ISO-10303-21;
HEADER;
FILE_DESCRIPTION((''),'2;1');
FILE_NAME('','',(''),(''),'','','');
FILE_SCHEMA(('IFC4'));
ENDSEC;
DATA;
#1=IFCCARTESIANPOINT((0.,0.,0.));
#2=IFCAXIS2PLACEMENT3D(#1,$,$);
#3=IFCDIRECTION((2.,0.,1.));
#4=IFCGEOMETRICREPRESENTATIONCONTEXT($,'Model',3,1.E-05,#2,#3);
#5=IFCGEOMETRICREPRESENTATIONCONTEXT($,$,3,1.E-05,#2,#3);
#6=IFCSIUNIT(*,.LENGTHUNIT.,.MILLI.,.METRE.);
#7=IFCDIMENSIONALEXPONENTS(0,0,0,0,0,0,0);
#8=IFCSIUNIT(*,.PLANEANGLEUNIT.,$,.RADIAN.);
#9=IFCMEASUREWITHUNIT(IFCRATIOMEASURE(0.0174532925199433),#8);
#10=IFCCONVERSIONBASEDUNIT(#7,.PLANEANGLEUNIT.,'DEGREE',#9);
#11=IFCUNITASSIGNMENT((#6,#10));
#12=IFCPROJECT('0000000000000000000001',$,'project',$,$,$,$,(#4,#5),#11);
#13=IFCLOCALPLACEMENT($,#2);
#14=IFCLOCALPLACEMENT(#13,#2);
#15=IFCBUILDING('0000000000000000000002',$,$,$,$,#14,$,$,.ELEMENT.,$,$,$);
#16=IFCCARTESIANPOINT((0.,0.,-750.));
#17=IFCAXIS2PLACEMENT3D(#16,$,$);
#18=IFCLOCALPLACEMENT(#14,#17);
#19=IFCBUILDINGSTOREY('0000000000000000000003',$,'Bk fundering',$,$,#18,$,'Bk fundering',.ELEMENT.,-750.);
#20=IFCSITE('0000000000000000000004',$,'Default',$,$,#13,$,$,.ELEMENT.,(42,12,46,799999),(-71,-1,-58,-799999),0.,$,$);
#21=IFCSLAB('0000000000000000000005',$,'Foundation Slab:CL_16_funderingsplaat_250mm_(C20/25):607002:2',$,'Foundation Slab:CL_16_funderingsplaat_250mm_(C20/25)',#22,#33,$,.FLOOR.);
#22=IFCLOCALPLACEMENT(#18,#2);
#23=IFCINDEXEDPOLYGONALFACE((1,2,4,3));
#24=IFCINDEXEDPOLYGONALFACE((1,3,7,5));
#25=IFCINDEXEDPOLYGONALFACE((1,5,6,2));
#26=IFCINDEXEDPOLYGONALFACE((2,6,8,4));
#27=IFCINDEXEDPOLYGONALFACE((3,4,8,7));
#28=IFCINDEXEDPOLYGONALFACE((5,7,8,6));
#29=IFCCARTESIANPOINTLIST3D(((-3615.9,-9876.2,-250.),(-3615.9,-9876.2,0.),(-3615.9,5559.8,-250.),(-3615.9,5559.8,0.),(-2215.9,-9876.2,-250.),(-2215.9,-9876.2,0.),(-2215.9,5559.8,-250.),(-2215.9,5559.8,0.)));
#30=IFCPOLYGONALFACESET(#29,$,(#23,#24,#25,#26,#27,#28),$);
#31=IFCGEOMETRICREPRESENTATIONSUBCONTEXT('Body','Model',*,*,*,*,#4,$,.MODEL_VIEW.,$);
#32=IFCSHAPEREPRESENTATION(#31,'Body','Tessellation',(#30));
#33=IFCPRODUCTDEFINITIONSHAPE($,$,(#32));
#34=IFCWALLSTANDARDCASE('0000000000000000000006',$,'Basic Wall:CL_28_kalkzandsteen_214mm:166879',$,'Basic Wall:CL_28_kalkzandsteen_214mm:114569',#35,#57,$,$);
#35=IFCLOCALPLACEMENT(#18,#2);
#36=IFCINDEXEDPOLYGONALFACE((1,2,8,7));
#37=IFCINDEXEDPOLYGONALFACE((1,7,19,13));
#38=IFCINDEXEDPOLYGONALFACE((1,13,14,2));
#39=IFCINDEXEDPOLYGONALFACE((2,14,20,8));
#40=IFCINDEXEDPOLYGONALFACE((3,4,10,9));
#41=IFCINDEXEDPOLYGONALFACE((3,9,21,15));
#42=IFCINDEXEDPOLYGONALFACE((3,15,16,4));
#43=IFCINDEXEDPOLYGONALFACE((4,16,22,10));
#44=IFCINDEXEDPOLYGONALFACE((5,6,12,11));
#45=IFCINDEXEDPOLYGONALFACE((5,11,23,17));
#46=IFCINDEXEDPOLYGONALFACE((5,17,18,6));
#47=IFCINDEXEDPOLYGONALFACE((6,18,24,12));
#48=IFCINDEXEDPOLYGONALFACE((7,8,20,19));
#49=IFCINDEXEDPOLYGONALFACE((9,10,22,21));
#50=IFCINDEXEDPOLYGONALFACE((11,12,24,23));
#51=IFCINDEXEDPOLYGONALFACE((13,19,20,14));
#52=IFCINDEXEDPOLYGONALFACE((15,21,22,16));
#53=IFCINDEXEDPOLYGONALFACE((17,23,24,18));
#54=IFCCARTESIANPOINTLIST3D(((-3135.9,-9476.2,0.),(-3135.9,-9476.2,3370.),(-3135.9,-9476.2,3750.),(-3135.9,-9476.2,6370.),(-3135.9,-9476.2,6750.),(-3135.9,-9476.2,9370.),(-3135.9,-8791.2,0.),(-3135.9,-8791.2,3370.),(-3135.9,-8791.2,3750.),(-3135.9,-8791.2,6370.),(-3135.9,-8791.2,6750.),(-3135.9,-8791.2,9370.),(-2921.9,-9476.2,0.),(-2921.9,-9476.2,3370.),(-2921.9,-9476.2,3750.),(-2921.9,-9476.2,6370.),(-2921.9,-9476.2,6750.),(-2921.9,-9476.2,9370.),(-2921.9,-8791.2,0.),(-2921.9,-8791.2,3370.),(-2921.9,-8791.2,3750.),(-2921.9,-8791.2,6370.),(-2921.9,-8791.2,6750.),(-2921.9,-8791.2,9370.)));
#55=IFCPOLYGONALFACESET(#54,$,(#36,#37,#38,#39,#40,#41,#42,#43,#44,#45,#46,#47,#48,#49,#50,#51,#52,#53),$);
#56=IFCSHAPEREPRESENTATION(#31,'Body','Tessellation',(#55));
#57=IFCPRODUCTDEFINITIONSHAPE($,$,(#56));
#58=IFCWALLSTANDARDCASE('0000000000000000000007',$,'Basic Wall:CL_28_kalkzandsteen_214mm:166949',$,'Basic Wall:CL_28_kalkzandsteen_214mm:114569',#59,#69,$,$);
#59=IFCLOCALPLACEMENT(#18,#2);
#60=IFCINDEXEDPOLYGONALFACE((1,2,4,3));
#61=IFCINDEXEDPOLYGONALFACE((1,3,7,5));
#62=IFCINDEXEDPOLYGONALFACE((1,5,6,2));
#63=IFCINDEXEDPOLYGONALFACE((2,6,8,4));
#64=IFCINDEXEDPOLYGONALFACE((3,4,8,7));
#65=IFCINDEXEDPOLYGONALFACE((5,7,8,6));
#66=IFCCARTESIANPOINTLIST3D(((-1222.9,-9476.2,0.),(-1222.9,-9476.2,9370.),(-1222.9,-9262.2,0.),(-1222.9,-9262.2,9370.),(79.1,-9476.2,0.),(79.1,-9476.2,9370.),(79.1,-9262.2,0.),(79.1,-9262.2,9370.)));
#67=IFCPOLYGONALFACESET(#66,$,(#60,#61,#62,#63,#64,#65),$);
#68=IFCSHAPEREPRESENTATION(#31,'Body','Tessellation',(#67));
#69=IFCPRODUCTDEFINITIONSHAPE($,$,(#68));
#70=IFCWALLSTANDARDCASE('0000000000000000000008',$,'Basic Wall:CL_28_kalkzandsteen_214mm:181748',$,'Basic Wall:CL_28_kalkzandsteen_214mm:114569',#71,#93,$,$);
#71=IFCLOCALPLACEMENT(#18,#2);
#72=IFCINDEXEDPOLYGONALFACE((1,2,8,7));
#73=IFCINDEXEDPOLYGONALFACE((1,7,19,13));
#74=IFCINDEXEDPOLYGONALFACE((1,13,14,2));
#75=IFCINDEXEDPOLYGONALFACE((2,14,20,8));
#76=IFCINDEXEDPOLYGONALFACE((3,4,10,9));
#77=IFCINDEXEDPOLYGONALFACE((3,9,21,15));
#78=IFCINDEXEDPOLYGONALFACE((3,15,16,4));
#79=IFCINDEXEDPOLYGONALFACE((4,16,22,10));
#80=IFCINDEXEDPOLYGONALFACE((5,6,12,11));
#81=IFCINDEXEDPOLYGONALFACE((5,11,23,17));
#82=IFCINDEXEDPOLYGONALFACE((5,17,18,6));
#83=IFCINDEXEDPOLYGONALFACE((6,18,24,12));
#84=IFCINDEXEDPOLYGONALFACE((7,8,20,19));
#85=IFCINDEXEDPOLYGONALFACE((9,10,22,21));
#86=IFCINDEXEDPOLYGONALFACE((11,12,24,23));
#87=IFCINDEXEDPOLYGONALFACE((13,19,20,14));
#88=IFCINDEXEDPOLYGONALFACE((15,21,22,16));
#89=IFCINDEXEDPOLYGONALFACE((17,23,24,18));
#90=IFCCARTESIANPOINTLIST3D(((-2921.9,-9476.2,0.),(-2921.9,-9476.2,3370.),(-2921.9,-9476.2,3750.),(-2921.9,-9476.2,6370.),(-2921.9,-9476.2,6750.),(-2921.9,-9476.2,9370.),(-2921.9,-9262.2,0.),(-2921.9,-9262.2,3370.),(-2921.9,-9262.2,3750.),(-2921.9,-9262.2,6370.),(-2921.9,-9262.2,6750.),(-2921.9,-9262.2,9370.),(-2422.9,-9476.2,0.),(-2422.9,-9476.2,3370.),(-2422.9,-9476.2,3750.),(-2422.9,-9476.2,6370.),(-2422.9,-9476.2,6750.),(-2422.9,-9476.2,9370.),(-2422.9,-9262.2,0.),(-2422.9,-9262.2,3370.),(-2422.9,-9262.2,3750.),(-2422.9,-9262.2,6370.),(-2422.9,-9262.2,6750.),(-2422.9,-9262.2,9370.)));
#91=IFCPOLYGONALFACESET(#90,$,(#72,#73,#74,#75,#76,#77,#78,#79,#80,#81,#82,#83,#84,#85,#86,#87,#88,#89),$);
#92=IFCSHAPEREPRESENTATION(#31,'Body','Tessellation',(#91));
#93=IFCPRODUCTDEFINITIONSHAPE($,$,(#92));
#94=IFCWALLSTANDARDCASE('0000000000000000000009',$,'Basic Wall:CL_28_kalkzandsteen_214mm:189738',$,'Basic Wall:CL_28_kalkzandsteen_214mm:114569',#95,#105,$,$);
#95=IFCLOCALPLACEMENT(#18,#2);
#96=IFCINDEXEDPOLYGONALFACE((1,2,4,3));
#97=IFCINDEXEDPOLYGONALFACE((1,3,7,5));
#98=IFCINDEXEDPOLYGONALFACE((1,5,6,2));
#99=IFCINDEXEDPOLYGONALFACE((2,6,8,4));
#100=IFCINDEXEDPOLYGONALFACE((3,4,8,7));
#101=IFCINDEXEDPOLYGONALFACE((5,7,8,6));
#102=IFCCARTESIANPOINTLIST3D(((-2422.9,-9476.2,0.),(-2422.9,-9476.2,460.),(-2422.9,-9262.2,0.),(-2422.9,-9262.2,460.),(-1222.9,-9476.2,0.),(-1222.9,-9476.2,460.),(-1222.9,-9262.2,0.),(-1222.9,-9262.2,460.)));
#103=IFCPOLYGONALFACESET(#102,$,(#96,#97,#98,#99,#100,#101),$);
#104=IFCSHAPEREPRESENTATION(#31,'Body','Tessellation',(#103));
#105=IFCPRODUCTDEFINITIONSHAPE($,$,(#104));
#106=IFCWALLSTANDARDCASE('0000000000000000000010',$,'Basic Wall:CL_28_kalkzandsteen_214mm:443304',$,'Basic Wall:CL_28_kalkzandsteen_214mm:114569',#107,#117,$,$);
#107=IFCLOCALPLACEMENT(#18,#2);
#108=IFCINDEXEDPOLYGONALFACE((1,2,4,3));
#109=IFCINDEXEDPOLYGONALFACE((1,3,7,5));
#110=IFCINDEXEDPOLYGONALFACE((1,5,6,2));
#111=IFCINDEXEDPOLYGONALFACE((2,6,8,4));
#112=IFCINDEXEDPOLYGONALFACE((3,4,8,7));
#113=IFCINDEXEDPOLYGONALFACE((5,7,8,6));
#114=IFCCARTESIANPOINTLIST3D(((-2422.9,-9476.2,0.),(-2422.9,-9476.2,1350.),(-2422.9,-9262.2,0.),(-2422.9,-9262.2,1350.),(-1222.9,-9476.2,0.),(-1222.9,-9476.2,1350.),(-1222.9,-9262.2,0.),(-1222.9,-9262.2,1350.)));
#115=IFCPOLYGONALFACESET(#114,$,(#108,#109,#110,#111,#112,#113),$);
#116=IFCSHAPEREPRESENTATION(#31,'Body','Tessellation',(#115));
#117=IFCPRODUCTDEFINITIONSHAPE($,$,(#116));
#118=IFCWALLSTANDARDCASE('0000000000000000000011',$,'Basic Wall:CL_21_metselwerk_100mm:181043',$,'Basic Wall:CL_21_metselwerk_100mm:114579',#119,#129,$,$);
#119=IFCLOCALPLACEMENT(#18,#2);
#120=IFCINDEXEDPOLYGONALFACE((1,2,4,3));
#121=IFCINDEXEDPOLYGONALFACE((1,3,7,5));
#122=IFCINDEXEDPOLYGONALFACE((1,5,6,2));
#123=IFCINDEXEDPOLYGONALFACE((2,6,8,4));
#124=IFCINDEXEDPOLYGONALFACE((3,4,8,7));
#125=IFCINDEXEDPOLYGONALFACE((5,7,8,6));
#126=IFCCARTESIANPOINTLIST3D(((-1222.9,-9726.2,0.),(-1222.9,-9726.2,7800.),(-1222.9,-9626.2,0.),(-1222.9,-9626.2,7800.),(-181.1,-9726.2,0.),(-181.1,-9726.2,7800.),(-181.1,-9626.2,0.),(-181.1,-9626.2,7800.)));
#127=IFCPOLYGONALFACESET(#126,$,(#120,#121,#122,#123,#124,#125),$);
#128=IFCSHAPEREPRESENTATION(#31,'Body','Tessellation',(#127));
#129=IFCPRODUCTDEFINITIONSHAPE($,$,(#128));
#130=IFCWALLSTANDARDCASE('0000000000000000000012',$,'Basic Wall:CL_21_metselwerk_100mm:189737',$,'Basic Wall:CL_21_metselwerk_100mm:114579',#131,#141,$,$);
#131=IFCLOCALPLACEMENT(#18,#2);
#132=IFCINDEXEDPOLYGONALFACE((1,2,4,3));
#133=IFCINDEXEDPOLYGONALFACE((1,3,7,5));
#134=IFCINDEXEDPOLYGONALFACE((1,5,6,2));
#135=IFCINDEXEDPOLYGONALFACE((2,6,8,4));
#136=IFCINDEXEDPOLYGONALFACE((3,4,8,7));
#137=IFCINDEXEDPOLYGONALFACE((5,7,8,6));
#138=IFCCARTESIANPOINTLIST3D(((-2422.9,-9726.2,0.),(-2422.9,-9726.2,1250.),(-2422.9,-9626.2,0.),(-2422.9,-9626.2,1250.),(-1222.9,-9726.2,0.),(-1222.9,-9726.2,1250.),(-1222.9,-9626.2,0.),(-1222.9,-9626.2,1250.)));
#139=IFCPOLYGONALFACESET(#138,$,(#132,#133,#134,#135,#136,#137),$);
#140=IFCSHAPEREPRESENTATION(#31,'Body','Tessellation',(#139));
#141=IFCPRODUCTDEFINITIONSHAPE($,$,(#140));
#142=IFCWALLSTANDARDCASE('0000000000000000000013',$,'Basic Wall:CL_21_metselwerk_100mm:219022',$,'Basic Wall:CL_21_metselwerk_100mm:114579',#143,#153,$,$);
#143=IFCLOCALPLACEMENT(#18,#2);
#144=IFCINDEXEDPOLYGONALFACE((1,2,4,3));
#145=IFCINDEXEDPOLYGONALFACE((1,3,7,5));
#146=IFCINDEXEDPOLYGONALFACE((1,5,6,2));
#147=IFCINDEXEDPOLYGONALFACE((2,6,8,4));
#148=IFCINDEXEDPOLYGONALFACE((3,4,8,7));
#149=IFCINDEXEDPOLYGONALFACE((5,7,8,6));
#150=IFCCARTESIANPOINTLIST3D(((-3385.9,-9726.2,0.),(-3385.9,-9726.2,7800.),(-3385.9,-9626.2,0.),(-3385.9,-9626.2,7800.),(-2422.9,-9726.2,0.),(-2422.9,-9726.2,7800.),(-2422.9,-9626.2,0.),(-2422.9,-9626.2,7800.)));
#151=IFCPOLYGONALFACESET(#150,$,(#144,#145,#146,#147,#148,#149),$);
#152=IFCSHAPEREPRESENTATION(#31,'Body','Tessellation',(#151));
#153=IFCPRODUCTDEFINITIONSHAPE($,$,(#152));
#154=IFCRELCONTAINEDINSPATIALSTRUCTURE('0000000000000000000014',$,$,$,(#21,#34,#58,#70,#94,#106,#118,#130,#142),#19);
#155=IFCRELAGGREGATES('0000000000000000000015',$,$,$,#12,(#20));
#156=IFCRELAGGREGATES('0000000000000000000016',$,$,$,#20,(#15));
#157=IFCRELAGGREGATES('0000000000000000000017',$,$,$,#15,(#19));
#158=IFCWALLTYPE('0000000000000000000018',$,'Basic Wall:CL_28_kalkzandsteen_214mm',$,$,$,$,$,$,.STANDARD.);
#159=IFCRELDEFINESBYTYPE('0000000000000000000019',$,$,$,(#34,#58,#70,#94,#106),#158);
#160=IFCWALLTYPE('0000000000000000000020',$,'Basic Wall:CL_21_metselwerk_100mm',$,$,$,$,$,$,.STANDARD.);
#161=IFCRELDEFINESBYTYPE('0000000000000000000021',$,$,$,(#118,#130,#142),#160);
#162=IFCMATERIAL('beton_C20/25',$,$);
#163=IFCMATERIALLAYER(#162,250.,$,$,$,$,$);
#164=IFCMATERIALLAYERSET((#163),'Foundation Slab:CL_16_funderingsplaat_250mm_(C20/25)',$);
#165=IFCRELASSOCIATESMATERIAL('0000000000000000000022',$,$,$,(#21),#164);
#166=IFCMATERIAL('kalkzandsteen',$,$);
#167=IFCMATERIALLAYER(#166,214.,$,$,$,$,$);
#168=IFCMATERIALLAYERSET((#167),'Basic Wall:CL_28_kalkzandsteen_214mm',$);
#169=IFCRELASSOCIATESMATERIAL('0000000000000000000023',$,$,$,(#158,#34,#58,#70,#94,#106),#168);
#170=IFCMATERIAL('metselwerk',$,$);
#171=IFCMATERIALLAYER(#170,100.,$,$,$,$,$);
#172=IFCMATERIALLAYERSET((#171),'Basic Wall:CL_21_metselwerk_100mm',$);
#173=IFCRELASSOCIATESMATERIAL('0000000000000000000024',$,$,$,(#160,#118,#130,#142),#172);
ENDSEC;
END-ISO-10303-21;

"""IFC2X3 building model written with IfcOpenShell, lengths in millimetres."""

from ifc_helpers import new_model, entity, si_unit, converted_unit, direction, frame, frame_2d, origin, place, context, subcontext, project, spatial, polyline, rectangle, extrude, clip, bounded_halfspace, material, layer, layer_set, layer_usage, type_object, element, save


model = new_model("IFC2X3")

# Units and contexts
model_context = context("Model", 3, precision=1e-05, world=origin(), true_north=direction((2.0, 0.0, 1.0)))
context_of_model = context(None, 3, precision=1e-05, world=origin(), true_north=direction((2.0, 0.0, 1.0)))
body_context = subcontext(model_context, "Body", "Model", "MODEL_VIEW")
ifc_project = project(units=[si_unit("LENGTHUNIT", "METRE", prefix="MILLI"), converted_unit("PLANEANGLEUNIT", "DEGREE", entity("IfcRatioMeasure", 0.0174532925199433), si_unit("PLANEANGLEUNIT", "RADIAN"), dimensions=[0, 0, 0, 0, 0, 0, 0])], contexts=[model_context, context_of_model])

# Site, building, storey
site_placement = place(None, origin())
site = spatial("IfcSite", under=ifc_project, at=site_placement, Name="Default", CompositionType="ELEMENT", RefLatitude=(42, 12, 46, 799999), RefLongitude=(-71, -1, -58, -799999), RefElevation=0.0)
building_placement = place(site_placement, origin())
building = spatial("IfcBuilding", under=site, at=building_placement, CompositionType="ELEMENT")
storey_placement = place(building_placement, frame((0.0, 0.0, -750.0)))
storey = spatial("IfcBuildingStorey", under=building, at=storey_placement, Name="Bk fundering", LongName="Bk fundering", CompositionType="ELEMENT", Elevation=-750.0)

# Slab
ifc_material_1 = material(Name="beton_C20/25")
ifc_layer_1 = layer(ifc_material_1, 250.0)
ifc_layer_set_1 = layer_set([ifc_layer_1], Name="Foundation Slab:CL_16_funderingsplaat_250mm_(C20/25)")
ifc_layer_usage_1 = layer_usage(ifc_layer_set_1, "AXIS3", "POSITIVE", 0.0)
slab_1_placement = place(storey_placement, frame((-3615.9, -9876.2, -250.0)))
element("IfcSlab", 1, at=slab_1_placement, inside=storey, material=ifc_layer_usage_1, Name="Foundation Slab:CL_16_funderingsplaat_250mm_(C20/25):607002:2", ObjectType="Foundation Slab:CL_16_funderingsplaat_250mm_(C20/25)", PredefinedType="FLOOR", context=body_context, shape_type="SweptSolid", body=[
    extrude(rectangle(XDim=15436.0, YDim=1400.0, at=frame_2d((7780.0, 0.0), x_axis=(0.0, -1.0))), frame((8480.0, 7718.0, 250.0), z_axis=(0.0, 0.0, -1.0), x_axis=(-1.0, 0.0, 0.0)), (0.0, 0.0, 1.0), 250.0),
])

# Wall, openings
ifc_material_2 = material(Name="kalkzandsteen")
ifc_layer_2 = layer(ifc_material_2, 214.0)
ifc_layer_set_2 = layer_set([ifc_layer_2], Name="Basic Wall:CL_28_kalkzandsteen_214mm")
ifc_layer_usage_2 = layer_usage(ifc_layer_set_2, "AXIS2", "NEGATIVE", 107.0)
wall_type_1 = type_object("IfcWallType", Name="Basic Wall:CL_28_kalkzandsteen_214mm", PredefinedType="STANDARD", material=ifc_layer_set_2)
wall_1_placement = place(storey_placement, frame((-3028.9, -8791.2, 0.0), z_axis=(0.0, 0.0, 1.0), x_axis=(0.0, -1.0, 0.0)))
wall_1 = element("IfcWallStandardCase", 2, at=wall_1_placement, inside=storey, type_object=wall_type_1, material=ifc_layer_usage_2, Name="Basic Wall:CL_28_kalkzandsteen_214mm:166879", ObjectType="Basic Wall:CL_28_kalkzandsteen_214mm:114569", context=body_context, shape_type="Clipping", body=[
    clip(extrude(rectangle(XDim=685.0, YDim=214.0, at=frame_2d((342.5, 0.0), x_axis=(-1.0, 0.0))), origin(), (0.0, 0.0, 1.0), 9370.0), bounded_halfspace(frame((0.0, -107.0, 9370.0), z_axis=(0.0, 0.0, -1.0), x_axis=(0.0, 1.0, 0.0)), True, frame((0.0, -107.0, 9370.0)), polyline([(0.0, 0.0), (685.0, 0.0), (685.0, 214.0), (471.0, 214.0), (0.0, 214.0), (0.0, 0.0)]))),
])
opening_1_placement = place(storey_placement, frame((-3028.9, -8791.2, 0.0), z_axis=(0.0, 0.0, 1.0), x_axis=(0.0, -1.0, 0.0)))
element("IfcOpeningElement", 3, at=opening_1_placement, cuts=wall_1, ObjectType="Opening", context=body_context, shape_type="SweptSolid", body=[
    extrude(rectangle(XDim=685.0, YDim=214.0, at=frame_2d((-25.7, -21.4), x_axis=(1.0, 0.0))), frame((368.2, 21.4, 3370.0)), (0.0, 0.0, 1.0), 380.0),
])
opening_2_placement = place(storey_placement, frame((-3028.9, -8791.2, 0.0), z_axis=(0.0, 0.0, 1.0), x_axis=(0.0, -1.0, 0.0)))
element("IfcOpeningElement", 4, at=opening_2_placement, cuts=wall_1, ObjectType="Opening", context=body_context, shape_type="SweptSolid", body=[
    extrude(rectangle(XDim=685.0, YDim=214.0, at=frame_2d((-25.7, -21.4), x_axis=(1.0, 0.0))), frame((368.2, 21.4, 6370.0)), (0.0, 0.0, 1.0), 380.0),
])

# Wall
ifc_layer_usage_3 = layer_usage(ifc_layer_set_2, "AXIS2", "NEGATIVE", 107.0)
wall_2_placement = place(storey_placement, frame((-1222.9, -9369.2, 0.0)))
element("IfcWallStandardCase", 5, at=wall_2_placement, inside=storey, type_object=wall_type_1, material=ifc_layer_usage_3, Name="Basic Wall:CL_28_kalkzandsteen_214mm:166949", ObjectType="Basic Wall:CL_28_kalkzandsteen_214mm:114569", context=body_context, shape_type="Clipping", body=[
    clip(extrude(rectangle(XDim=1302.0, YDim=214.0, at=frame_2d((651.0, 0.0), x_axis=(-1.0, 0.0))), origin(), (0.0, 0.0, 1.0), 9370.0), bounded_halfspace(frame((0.0, -107.0, 9370.0), z_axis=(0.0, 0.0, -1.0), x_axis=(1.0, 0.0, 0.0)), True, frame((0.0, -107.0, 9370.0)), polyline([(0.0, 0.0), (1302.0, 0.0), (1302.0, 214.0), (0.0, 214.0), (0.0, 0.0)]))),
])

# Wall, openings
ifc_layer_usage_4 = layer_usage(ifc_layer_set_2, "AXIS2", "NEGATIVE", 107.0)
wall_3_placement = place(storey_placement, frame((-2921.9, -9369.2, 0.0)))
wall_3 = element("IfcWallStandardCase", 6, at=wall_3_placement, inside=storey, type_object=wall_type_1, material=ifc_layer_usage_4, Name="Basic Wall:CL_28_kalkzandsteen_214mm:181748", ObjectType="Basic Wall:CL_28_kalkzandsteen_214mm:114569", context=body_context, shape_type="Clipping", body=[
    clip(extrude(rectangle(XDim=499.0, YDim=214.0, at=frame_2d((249.5, 0.0), x_axis=(-1.0, 0.0))), origin(), (0.0, 0.0, 1.0), 9370.0), bounded_halfspace(frame((0.0, -107.0, 9370.0), z_axis=(0.0, 0.0, -1.0), x_axis=(1.0, 0.0, 0.0)), True, frame((0.0, -107.0, 9370.0)), polyline([(0.0, 0.0), (499.0, 0.0), (499.0, 214.0), (0.0, 214.0), (0.0, 0.0)]))),
])
opening_3_placement = place(storey_placement, frame((-2921.9, -9369.2, 0.0)))
element("IfcOpeningElement", 7, at=opening_3_placement, cuts=wall_3, ObjectType="Opening", context=body_context, shape_type="SweptSolid", body=[
    extrude(rectangle(XDim=499.0, YDim=214.0, at=frame_2d((0.0, 0.0), x_axis=(1.0, 0.0))), frame((249.5, 0.0, 3370.0)), (0.0, 0.0, 1.0), 380.0),
])
opening_4_placement = place(storey_placement, frame((-2921.9, -9369.2, 0.0)))
element("IfcOpeningElement", 8, at=opening_4_placement, cuts=wall_3, ObjectType="Opening", context=body_context, shape_type="SweptSolid", body=[
    extrude(rectangle(XDim=499.0, YDim=214.0, at=frame_2d((0.0, 0.0), x_axis=(1.0, 0.0))), frame((249.5, 0.0, 6370.0)), (0.0, 0.0, 1.0), 380.0),
])

# Walls
ifc_layer_usage_5 = layer_usage(ifc_layer_set_2, "AXIS2", "NEGATIVE", 107.0)
wall_4_placement = place(storey_placement, frame((-2422.9, -9369.2, 0.0)))
element("IfcWallStandardCase", 9, at=wall_4_placement, inside=storey, type_object=wall_type_1, material=ifc_layer_usage_5, Name="Basic Wall:CL_28_kalkzandsteen_214mm:189738", ObjectType="Basic Wall:CL_28_kalkzandsteen_214mm:114569", context=body_context, shape_type="Clipping", body=[
    clip(extrude(rectangle(XDim=1200.0, YDim=214.0, at=frame_2d((600.0, 0.0), x_axis=(-1.0, 0.0))), origin(), (0.0, 0.0, 1.0), 460.0), bounded_halfspace(frame((0.0, -107.0, 460.0), z_axis=(0.0, 0.0, -1.0), x_axis=(0.0, -1.0, 0.0)), True, frame((0.0, -107.0, 460.0)), polyline([(0.0, 0.0), (1200.0, 0.0), (1200.0, 214.0), (0.0, 214.0), (0.0, 0.0)]))),
])
ifc_layer_usage_6 = layer_usage(ifc_layer_set_2, "AXIS2", "NEGATIVE", 107.0)
wall_5_placement = place(storey_placement, frame((-2422.9, -9369.2, 0.0)))
element("IfcWallStandardCase", 10, at=wall_5_placement, inside=storey, type_object=wall_type_1, material=ifc_layer_usage_6, Name="Basic Wall:CL_28_kalkzandsteen_214mm:443304", ObjectType="Basic Wall:CL_28_kalkzandsteen_214mm:114569", context=body_context, shape_type="SweptSolid", body=[
    extrude(rectangle(XDim=1200.0, YDim=214.0, at=frame_2d((600.0, 0.0), x_axis=(-1.0, 0.0))), origin(), (0.0, 0.0, 1.0), 1350.0),
])
ifc_material_3 = material(Name="metselwerk")
ifc_layer_3 = layer(ifc_material_3, 100.0)
ifc_layer_set_3 = layer_set([ifc_layer_3], Name="Basic Wall:CL_21_metselwerk_100mm")
ifc_layer_usage_7 = layer_usage(ifc_layer_set_3, "AXIS2", "NEGATIVE", 50.0)
wall_type_2 = type_object("IfcWallType", Name="Basic Wall:CL_21_metselwerk_100mm", PredefinedType="STANDARD", material=ifc_layer_set_3)
wall_6_placement = place(storey_placement, frame((-1222.9, -9676.2, 0.0)))
element("IfcWallStandardCase", 11, at=wall_6_placement, inside=storey, type_object=wall_type_2, material=ifc_layer_usage_7, Name="Basic Wall:CL_21_metselwerk_100mm:181043", ObjectType="Basic Wall:CL_21_metselwerk_100mm:114579", context=body_context, shape_type="SweptSolid", body=[
    extrude(rectangle(XDim=1041.8, YDim=100.0, at=frame_2d((520.9, 0.0), x_axis=(-1.0, 0.0))), origin(), (0.0, 0.0, 1.0), 7800.0),
])
ifc_layer_usage_8 = layer_usage(ifc_layer_set_3, "AXIS2", "NEGATIVE", 50.0)
wall_7_placement = place(storey_placement, frame((-2422.9, -9676.2, 0.0)))
element("IfcWallStandardCase", 12, at=wall_7_placement, inside=storey, type_object=wall_type_2, material=ifc_layer_usage_8, Name="Basic Wall:CL_21_metselwerk_100mm:189737", ObjectType="Basic Wall:CL_21_metselwerk_100mm:114579", context=body_context, shape_type="SweptSolid", body=[
    extrude(rectangle(XDim=1200.0, YDim=100.0, at=frame_2d((600.0, 0.0), x_axis=(-1.0, 0.0))), origin(), (0.0, 0.0, 1.0), 1250.0),
])
ifc_layer_usage_9 = layer_usage(ifc_layer_set_3, "AXIS2", "NEGATIVE", 50.0)
wall_8_placement = place(storey_placement, frame((-3385.9, -9676.2, 0.0)))
element("IfcWallStandardCase", 13, at=wall_8_placement, inside=storey, type_object=wall_type_2, material=ifc_layer_usage_9, Name="Basic Wall:CL_21_metselwerk_100mm:219022", ObjectType="Basic Wall:CL_21_metselwerk_100mm:114579", context=body_context, shape_type="SweptSolid", body=[
    extrude(rectangle(XDim=963.0, YDim=100.0, at=frame_2d((481.5, 0.0), x_axis=(-1.0, 0.0))), origin(), (0.0, 0.0, 1.0), 7800.0),
])

save(model, "model.ifc")
